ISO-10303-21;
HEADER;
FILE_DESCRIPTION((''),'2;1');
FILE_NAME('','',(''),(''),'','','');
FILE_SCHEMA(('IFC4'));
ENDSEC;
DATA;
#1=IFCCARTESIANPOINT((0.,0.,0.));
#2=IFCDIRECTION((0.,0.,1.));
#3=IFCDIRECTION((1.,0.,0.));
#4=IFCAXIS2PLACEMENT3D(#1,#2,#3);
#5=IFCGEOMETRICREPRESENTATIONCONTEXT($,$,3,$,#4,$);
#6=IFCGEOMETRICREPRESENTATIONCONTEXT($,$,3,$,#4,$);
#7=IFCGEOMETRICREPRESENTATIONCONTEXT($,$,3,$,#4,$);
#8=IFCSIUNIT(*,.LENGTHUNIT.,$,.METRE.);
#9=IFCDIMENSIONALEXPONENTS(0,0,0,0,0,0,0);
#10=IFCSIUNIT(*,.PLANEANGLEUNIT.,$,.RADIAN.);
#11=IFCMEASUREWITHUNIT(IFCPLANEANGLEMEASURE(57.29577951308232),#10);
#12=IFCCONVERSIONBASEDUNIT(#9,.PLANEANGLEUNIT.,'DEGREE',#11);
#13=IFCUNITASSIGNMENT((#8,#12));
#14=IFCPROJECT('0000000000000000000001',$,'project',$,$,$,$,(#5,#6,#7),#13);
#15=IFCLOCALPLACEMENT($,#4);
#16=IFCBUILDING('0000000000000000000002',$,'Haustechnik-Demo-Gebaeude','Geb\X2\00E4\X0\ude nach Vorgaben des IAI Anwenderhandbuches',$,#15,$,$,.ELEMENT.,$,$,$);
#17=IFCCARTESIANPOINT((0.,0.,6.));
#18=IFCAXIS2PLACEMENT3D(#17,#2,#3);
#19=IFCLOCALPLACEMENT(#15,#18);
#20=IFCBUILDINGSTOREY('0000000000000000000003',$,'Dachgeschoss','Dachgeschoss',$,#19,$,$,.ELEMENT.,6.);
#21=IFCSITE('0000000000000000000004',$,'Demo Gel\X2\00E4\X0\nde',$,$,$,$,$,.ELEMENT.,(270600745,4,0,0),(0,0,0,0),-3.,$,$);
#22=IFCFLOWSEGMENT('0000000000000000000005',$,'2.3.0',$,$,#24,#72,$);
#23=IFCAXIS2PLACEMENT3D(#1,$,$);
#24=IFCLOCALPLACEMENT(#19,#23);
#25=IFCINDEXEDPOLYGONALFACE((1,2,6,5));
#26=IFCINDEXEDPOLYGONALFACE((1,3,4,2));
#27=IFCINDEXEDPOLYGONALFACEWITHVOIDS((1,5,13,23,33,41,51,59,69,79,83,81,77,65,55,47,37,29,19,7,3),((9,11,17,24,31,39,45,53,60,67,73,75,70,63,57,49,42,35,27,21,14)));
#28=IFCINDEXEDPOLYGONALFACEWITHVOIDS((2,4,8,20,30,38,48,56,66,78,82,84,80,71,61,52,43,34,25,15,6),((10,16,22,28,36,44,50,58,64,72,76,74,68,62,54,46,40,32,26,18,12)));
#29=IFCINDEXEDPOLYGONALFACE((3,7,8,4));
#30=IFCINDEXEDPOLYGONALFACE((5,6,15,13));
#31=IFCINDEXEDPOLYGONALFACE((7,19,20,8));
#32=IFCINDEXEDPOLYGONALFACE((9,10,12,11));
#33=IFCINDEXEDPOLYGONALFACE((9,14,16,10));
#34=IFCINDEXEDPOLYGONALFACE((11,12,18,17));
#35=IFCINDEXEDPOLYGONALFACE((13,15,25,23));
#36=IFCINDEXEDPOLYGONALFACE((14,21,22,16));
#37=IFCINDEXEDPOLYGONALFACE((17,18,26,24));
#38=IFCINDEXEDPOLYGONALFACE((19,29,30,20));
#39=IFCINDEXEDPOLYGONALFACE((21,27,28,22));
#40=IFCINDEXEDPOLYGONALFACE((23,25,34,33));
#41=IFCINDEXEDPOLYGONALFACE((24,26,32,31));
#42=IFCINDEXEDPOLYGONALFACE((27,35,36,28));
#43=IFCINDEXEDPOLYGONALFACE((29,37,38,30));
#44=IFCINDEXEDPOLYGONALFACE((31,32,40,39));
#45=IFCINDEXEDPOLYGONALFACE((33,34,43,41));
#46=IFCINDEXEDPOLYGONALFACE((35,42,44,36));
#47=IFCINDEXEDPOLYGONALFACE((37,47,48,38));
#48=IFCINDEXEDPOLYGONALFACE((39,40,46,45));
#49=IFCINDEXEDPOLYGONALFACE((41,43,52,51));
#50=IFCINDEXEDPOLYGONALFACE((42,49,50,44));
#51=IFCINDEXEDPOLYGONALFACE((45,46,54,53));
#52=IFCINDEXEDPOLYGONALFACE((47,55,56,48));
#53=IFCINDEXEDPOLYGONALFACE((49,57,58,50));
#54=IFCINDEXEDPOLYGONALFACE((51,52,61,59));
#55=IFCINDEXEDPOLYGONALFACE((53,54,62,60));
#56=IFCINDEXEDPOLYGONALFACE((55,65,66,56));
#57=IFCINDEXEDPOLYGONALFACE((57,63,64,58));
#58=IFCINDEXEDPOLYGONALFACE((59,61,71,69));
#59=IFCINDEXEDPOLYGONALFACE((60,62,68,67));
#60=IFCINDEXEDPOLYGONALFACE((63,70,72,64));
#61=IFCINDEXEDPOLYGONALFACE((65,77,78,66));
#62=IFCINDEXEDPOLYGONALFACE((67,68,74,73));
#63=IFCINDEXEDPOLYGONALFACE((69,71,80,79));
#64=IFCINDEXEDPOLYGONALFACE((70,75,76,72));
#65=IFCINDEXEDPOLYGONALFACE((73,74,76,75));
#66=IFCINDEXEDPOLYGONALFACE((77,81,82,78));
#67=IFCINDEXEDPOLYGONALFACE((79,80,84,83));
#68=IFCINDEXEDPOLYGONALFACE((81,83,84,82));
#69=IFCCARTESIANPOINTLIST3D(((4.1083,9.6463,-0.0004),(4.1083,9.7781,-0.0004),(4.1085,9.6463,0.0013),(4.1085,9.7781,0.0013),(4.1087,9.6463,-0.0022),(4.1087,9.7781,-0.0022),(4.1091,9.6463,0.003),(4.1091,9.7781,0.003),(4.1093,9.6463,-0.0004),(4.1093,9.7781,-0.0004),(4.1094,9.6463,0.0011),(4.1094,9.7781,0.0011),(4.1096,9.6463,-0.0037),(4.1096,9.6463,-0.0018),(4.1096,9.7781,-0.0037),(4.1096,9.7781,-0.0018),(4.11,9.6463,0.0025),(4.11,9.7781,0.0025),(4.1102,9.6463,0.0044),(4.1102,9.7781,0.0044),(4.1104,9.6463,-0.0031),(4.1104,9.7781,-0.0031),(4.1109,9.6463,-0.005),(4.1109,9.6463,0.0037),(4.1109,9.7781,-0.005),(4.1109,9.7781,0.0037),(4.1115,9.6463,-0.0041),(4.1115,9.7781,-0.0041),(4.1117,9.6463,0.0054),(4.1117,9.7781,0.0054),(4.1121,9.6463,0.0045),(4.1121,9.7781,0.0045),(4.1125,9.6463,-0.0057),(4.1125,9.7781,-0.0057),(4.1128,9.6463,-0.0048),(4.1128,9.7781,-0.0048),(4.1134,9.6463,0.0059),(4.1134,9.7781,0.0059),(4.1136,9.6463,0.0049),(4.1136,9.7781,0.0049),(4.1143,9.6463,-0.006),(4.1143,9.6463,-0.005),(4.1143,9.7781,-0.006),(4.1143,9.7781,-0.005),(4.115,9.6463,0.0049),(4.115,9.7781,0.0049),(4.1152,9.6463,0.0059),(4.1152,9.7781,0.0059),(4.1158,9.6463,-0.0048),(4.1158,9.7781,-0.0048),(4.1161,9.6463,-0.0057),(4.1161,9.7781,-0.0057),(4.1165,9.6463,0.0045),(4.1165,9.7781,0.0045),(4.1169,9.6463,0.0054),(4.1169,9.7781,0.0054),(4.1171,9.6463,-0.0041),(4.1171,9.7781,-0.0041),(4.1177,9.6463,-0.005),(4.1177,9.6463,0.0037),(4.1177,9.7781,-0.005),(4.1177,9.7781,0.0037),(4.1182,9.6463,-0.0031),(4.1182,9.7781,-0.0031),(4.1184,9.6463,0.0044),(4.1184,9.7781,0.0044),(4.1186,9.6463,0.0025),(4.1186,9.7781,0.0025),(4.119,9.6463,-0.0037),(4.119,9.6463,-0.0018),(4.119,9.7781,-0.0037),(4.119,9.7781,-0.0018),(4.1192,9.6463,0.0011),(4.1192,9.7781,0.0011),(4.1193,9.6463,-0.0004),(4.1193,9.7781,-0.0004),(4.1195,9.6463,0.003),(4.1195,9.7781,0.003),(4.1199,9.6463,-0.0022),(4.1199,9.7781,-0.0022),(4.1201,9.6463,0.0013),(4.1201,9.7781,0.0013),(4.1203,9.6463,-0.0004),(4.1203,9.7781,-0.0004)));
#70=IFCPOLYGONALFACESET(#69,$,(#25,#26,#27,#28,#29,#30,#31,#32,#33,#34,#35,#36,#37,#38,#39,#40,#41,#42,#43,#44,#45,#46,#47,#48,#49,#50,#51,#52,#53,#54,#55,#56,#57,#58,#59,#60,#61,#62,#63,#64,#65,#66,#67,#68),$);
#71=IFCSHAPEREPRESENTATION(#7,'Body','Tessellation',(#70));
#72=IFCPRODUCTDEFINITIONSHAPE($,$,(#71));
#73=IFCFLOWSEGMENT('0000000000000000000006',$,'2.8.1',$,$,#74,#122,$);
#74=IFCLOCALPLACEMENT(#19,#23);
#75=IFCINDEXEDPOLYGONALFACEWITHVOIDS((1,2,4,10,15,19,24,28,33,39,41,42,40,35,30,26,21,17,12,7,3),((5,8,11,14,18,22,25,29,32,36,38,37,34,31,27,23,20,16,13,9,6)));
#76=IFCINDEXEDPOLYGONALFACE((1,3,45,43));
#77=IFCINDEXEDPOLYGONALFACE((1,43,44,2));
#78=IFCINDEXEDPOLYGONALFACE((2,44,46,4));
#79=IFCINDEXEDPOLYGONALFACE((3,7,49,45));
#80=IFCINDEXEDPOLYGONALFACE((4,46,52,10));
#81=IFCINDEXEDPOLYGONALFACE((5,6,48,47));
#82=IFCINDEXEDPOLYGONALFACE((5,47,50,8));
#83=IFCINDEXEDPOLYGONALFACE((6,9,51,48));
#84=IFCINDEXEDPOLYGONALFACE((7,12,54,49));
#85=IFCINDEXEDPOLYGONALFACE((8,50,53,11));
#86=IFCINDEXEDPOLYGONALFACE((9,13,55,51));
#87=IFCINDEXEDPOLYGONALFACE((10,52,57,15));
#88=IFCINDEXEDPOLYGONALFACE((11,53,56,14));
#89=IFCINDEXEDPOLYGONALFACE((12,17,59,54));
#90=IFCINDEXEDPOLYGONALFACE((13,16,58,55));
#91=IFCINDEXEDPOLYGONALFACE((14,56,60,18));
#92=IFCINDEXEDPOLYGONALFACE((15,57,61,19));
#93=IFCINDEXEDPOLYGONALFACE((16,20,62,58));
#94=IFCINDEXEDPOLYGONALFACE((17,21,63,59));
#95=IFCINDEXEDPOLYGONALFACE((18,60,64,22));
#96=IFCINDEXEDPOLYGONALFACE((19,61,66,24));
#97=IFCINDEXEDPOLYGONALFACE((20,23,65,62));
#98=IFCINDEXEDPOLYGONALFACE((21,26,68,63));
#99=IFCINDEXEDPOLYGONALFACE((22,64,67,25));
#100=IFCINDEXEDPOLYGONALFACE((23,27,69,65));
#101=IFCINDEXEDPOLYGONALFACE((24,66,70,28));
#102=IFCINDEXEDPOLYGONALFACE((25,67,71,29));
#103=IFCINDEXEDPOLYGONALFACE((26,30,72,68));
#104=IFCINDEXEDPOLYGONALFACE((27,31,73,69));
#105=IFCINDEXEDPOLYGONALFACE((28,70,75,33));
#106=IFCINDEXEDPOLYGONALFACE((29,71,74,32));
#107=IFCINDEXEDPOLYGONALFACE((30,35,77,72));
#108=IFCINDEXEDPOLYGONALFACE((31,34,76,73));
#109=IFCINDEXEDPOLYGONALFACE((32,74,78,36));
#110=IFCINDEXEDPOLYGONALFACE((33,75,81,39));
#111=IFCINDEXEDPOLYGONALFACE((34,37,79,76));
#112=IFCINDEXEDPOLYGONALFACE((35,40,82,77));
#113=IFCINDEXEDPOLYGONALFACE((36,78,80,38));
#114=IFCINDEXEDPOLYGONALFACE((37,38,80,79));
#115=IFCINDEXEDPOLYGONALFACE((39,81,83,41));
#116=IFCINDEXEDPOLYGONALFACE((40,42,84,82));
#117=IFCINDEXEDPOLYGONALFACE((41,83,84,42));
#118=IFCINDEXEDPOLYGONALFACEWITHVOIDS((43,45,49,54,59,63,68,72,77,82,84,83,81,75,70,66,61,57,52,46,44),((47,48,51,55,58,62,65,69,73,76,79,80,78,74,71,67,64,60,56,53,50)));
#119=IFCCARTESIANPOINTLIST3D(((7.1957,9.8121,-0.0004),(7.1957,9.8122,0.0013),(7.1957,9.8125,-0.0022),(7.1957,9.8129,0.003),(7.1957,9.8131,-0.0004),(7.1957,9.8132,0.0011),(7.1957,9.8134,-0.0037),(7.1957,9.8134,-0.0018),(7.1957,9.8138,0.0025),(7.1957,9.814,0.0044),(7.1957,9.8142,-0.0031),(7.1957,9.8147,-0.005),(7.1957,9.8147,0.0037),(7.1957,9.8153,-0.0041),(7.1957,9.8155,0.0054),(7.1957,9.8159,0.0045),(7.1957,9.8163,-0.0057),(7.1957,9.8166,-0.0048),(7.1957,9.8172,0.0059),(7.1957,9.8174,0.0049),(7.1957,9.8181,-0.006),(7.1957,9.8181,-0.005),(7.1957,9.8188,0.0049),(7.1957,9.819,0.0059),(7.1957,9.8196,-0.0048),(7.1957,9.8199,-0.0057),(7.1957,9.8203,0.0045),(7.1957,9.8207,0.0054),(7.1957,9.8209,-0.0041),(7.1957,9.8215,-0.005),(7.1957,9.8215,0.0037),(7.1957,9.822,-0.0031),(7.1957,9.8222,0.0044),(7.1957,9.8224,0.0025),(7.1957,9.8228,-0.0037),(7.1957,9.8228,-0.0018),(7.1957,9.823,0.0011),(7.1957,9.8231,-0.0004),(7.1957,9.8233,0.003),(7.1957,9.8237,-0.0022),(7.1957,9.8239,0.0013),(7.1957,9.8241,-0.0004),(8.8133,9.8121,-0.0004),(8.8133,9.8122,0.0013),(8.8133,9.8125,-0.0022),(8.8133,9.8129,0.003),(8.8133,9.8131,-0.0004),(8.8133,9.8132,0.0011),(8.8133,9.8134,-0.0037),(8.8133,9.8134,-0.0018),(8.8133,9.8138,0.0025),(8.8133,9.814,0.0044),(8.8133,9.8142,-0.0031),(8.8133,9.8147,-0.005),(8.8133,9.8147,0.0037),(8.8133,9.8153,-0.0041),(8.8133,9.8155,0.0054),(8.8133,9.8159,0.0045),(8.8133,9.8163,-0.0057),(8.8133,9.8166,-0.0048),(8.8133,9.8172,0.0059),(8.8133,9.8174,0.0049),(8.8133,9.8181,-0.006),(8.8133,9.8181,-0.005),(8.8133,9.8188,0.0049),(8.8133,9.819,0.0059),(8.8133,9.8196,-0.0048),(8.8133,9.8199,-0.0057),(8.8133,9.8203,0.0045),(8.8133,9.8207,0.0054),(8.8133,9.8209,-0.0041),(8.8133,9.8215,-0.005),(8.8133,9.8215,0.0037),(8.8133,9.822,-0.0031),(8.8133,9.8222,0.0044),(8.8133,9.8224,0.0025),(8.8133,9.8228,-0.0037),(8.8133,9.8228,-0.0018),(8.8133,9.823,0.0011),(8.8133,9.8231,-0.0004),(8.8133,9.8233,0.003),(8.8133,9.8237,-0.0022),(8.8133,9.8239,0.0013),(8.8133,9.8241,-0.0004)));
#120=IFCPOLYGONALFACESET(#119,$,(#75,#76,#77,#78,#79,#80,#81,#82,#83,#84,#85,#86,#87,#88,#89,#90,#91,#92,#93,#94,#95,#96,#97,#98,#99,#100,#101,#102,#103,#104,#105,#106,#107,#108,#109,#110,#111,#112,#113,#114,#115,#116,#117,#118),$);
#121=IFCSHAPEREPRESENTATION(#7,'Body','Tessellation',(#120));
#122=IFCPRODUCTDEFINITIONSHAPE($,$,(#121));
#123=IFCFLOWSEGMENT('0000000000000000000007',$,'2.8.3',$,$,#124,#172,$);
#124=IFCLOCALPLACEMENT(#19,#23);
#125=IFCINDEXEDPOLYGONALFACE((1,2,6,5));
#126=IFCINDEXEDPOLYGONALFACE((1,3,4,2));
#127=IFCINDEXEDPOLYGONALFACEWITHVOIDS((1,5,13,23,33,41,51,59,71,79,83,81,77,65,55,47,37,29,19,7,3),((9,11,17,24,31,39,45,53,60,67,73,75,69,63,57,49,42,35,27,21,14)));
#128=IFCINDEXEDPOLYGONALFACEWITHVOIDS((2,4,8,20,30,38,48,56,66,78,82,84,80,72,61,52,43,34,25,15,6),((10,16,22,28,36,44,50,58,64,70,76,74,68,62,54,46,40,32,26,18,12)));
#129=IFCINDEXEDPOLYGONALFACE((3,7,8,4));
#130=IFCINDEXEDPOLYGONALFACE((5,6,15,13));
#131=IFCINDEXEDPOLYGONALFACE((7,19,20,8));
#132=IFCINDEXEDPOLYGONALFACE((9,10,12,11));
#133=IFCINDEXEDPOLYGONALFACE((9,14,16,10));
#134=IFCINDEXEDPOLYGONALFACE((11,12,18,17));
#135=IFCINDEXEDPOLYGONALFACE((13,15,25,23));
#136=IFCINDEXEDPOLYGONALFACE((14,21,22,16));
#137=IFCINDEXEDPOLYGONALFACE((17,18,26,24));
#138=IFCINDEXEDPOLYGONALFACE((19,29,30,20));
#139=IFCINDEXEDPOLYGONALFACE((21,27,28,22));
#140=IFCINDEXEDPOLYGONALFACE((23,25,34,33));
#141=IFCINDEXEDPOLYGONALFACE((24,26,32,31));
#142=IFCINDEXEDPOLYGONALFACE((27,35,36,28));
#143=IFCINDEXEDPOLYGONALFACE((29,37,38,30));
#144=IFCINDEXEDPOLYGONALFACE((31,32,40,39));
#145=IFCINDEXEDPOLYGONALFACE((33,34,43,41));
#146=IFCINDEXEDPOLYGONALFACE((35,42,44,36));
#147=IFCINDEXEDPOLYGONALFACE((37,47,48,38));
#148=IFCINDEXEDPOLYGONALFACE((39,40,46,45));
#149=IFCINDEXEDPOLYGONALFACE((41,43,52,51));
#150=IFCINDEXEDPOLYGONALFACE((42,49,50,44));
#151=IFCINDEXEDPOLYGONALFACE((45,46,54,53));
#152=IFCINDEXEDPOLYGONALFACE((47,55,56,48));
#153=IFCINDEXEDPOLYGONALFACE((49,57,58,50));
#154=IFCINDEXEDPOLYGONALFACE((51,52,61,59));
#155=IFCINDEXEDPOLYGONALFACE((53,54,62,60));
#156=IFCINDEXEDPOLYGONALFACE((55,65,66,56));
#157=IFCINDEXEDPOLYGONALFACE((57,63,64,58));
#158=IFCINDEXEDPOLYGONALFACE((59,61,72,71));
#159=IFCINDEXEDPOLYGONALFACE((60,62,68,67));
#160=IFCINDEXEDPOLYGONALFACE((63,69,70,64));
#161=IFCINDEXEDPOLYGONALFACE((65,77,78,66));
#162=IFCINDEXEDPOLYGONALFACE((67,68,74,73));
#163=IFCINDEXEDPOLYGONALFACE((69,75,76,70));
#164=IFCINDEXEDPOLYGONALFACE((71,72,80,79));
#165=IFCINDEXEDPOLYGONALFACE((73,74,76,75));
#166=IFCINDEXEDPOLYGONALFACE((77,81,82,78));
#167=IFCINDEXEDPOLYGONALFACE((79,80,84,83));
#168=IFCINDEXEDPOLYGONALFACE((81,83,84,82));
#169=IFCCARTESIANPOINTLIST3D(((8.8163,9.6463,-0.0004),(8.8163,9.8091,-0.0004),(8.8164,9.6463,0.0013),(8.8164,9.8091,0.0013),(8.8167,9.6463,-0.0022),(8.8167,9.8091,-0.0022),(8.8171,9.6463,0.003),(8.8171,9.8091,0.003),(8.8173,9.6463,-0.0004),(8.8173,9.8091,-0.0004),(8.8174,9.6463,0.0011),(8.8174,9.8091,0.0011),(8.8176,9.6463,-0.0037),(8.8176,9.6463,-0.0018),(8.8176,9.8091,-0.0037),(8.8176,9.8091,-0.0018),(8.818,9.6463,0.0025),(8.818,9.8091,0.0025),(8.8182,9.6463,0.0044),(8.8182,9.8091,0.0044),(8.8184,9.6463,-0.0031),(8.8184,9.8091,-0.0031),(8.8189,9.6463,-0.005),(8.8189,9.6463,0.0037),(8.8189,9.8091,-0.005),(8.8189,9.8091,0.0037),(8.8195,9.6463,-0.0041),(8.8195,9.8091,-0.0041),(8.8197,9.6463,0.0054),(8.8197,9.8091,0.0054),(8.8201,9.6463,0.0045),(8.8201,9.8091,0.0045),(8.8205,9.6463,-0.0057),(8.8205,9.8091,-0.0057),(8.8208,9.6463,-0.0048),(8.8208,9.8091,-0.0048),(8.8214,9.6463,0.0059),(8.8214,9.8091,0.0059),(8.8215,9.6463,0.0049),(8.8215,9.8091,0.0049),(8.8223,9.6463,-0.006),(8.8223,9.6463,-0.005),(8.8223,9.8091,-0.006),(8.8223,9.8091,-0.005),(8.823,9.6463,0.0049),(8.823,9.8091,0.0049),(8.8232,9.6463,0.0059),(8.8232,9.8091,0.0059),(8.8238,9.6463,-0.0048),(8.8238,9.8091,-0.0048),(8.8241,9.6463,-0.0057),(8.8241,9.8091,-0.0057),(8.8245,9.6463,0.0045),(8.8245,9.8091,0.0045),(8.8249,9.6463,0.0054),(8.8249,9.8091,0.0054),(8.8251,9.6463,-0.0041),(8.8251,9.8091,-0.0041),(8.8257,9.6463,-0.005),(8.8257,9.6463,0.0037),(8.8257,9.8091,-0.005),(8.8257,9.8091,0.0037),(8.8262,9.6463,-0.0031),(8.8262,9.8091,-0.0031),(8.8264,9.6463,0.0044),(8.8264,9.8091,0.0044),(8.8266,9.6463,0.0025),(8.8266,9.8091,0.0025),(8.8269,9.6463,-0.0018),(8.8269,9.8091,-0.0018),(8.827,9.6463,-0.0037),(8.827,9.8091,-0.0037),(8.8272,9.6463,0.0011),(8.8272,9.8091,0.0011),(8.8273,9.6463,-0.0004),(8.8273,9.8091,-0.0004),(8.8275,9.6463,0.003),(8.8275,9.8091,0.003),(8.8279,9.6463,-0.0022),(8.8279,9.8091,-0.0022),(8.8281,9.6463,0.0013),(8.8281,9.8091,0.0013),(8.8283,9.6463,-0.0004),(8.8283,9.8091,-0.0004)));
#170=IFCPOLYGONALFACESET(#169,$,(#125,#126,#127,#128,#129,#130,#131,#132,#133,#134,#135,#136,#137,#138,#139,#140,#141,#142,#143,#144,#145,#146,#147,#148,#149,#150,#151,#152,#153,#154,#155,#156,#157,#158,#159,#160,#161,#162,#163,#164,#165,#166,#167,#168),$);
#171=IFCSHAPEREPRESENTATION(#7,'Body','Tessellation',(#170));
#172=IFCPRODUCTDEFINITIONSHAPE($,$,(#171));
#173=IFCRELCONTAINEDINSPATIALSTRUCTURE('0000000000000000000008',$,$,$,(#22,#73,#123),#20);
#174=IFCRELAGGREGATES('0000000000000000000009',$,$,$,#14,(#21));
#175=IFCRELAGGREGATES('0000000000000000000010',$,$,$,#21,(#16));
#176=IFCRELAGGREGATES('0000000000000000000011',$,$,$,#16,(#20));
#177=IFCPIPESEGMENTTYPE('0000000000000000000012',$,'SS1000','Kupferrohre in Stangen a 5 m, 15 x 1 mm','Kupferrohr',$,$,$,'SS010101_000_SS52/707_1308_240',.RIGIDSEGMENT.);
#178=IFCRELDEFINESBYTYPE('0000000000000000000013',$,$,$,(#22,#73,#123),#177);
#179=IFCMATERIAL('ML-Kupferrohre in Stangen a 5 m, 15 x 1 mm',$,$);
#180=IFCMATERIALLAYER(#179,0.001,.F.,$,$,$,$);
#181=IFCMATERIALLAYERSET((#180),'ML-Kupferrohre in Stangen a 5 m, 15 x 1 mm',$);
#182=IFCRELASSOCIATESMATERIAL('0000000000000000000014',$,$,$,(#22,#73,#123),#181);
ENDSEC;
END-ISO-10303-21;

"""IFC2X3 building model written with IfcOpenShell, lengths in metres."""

from ifc_helpers import new_model, entity, si_unit, converted_unit, frame, origin_with_axes, origin_2d_with_axis, place, context, project, spatial, hollow_circle, extrude, material, layer, layer_set, layer_usage, type_object, element, save


model = new_model("IFC2X3")

# Units and contexts
context_of_model_1 = context(None, 3, world=origin_with_axes())
context_of_model_2 = context(None, 3, world=origin_with_axes())
context_of_model_3 = context(None, 3, world=origin_with_axes())
ifc_project = project(units=[si_unit("LENGTHUNIT", "METRE"), converted_unit("PLANEANGLEUNIT", "DEGREE", entity("IfcPlaneAngleMeasure", 57.29577951308232), si_unit("PLANEANGLEUNIT", "RADIAN"), dimensions=[0, 0, 0, 0, 0, 0, 0])], contexts=[context_of_model_1, context_of_model_2, context_of_model_3])

# Site, building, storey
site = spatial("IfcSite", under=ifc_project, Name="Demo Gelände", CompositionType="ELEMENT", RefLatitude=(270600745, 4, 0, 0), RefLongitude=(0, 0, 0, 0), RefElevation=-3.0)
building_placement = place(None, origin_with_axes())
building = spatial("IfcBuilding", under=site, at=building_placement, Name="Haustechnik-Demo-Gebaeude", Description="Gebäude nach Vorgaben des IAI Anwenderhandbuches", CompositionType="ELEMENT")
storey_placement = place(building_placement, frame((0.0, 0.0, 6.0), z_axis=(0.0, 0.0, 1.0), x_axis=(1.0, 0.0, 0.0)))
storey = spatial("IfcBuildingStorey", under=building, at=storey_placement, Name="Dachgeschoss", Description="Dachgeschoss", CompositionType="ELEMENT", Elevation=6.0)

# Flow segments
ifc_material = material(Name="ML-Kupferrohre in Stangen a 5 m, 15 x 1 mm")
ifc_layer = layer(ifc_material, 0.001, ventilated=False)
ifc_layer_set = layer_set([ifc_layer], Name="ML-Kupferrohre in Stangen a 5 m, 15 x 1 mm")
ifc_layer_usage = layer_usage(ifc_layer_set, "AXIS2", "POSITIVE", 0.0)
pipe_segment_type_1 = type_object("IfcPipeSegmentType", Name="SS1000", Description="Kupferrohre in Stangen a 5 m, 15 x 1 mm", ApplicableOccurrence="Kupferrohr", ElementType="SS010101_000_SS52/707_1308_240", PredefinedType="RIGIDSEGMENT")
flow_segment_1_placement = place(storey_placement, frame((4.1143, 9.6463, 0.0), z_axis=(0.0, 1.0, 0.0), x_axis=(0.0, 0.0, -1.0)))
element("IfcFlowSegment", 1, at=flow_segment_1_placement, inside=storey, type_object=pipe_segment_type_1, material=ifc_layer_usage, Name="2.3.0", context=context_of_model_3, shape_type="SweptSolid", body=[
    extrude(hollow_circle(Radius=0.006, WallThickness=0.001, at=origin_2d_with_axis()), origin_with_axes(), (0.0, 0.0, 1.0), 0.1318),
])
flow_segment_2_placement = place(storey_placement, frame((7.1957, 9.8181, 0.0), z_axis=(1.0, 0.0, 0.0), x_axis=(0.0, 0.0, -1.0)))
element("IfcFlowSegment", 2, at=flow_segment_2_placement, inside=storey, type_object=pipe_segment_type_1, material=ifc_layer_usage, Name="2.8.1", context=context_of_model_3, shape_type="SweptSolid", body=[
    extrude(hollow_circle(Radius=0.006, WallThickness=0.001, at=origin_2d_with_axis()), origin_with_axes(), (0.0, 0.0, 1.0), 1.6175),
])
flow_segment_3_placement = place(storey_placement, frame((8.8223, 9.8091, 0.0), z_axis=(0.0, -1.0, 0.0), x_axis=(0.0, 0.0, -1.0)))
element("IfcFlowSegment", 3, at=flow_segment_3_placement, inside=storey, type_object=pipe_segment_type_1, material=ifc_layer_usage, Name="2.8.3", context=context_of_model_3, shape_type="SweptSolid", body=[
    extrude(hollow_circle(Radius=0.006, WallThickness=0.001, at=origin_2d_with_axis()), origin_with_axes(), (0.0, 0.0, 1.0), 0.1628),
])

save(model, "model.ifc")
